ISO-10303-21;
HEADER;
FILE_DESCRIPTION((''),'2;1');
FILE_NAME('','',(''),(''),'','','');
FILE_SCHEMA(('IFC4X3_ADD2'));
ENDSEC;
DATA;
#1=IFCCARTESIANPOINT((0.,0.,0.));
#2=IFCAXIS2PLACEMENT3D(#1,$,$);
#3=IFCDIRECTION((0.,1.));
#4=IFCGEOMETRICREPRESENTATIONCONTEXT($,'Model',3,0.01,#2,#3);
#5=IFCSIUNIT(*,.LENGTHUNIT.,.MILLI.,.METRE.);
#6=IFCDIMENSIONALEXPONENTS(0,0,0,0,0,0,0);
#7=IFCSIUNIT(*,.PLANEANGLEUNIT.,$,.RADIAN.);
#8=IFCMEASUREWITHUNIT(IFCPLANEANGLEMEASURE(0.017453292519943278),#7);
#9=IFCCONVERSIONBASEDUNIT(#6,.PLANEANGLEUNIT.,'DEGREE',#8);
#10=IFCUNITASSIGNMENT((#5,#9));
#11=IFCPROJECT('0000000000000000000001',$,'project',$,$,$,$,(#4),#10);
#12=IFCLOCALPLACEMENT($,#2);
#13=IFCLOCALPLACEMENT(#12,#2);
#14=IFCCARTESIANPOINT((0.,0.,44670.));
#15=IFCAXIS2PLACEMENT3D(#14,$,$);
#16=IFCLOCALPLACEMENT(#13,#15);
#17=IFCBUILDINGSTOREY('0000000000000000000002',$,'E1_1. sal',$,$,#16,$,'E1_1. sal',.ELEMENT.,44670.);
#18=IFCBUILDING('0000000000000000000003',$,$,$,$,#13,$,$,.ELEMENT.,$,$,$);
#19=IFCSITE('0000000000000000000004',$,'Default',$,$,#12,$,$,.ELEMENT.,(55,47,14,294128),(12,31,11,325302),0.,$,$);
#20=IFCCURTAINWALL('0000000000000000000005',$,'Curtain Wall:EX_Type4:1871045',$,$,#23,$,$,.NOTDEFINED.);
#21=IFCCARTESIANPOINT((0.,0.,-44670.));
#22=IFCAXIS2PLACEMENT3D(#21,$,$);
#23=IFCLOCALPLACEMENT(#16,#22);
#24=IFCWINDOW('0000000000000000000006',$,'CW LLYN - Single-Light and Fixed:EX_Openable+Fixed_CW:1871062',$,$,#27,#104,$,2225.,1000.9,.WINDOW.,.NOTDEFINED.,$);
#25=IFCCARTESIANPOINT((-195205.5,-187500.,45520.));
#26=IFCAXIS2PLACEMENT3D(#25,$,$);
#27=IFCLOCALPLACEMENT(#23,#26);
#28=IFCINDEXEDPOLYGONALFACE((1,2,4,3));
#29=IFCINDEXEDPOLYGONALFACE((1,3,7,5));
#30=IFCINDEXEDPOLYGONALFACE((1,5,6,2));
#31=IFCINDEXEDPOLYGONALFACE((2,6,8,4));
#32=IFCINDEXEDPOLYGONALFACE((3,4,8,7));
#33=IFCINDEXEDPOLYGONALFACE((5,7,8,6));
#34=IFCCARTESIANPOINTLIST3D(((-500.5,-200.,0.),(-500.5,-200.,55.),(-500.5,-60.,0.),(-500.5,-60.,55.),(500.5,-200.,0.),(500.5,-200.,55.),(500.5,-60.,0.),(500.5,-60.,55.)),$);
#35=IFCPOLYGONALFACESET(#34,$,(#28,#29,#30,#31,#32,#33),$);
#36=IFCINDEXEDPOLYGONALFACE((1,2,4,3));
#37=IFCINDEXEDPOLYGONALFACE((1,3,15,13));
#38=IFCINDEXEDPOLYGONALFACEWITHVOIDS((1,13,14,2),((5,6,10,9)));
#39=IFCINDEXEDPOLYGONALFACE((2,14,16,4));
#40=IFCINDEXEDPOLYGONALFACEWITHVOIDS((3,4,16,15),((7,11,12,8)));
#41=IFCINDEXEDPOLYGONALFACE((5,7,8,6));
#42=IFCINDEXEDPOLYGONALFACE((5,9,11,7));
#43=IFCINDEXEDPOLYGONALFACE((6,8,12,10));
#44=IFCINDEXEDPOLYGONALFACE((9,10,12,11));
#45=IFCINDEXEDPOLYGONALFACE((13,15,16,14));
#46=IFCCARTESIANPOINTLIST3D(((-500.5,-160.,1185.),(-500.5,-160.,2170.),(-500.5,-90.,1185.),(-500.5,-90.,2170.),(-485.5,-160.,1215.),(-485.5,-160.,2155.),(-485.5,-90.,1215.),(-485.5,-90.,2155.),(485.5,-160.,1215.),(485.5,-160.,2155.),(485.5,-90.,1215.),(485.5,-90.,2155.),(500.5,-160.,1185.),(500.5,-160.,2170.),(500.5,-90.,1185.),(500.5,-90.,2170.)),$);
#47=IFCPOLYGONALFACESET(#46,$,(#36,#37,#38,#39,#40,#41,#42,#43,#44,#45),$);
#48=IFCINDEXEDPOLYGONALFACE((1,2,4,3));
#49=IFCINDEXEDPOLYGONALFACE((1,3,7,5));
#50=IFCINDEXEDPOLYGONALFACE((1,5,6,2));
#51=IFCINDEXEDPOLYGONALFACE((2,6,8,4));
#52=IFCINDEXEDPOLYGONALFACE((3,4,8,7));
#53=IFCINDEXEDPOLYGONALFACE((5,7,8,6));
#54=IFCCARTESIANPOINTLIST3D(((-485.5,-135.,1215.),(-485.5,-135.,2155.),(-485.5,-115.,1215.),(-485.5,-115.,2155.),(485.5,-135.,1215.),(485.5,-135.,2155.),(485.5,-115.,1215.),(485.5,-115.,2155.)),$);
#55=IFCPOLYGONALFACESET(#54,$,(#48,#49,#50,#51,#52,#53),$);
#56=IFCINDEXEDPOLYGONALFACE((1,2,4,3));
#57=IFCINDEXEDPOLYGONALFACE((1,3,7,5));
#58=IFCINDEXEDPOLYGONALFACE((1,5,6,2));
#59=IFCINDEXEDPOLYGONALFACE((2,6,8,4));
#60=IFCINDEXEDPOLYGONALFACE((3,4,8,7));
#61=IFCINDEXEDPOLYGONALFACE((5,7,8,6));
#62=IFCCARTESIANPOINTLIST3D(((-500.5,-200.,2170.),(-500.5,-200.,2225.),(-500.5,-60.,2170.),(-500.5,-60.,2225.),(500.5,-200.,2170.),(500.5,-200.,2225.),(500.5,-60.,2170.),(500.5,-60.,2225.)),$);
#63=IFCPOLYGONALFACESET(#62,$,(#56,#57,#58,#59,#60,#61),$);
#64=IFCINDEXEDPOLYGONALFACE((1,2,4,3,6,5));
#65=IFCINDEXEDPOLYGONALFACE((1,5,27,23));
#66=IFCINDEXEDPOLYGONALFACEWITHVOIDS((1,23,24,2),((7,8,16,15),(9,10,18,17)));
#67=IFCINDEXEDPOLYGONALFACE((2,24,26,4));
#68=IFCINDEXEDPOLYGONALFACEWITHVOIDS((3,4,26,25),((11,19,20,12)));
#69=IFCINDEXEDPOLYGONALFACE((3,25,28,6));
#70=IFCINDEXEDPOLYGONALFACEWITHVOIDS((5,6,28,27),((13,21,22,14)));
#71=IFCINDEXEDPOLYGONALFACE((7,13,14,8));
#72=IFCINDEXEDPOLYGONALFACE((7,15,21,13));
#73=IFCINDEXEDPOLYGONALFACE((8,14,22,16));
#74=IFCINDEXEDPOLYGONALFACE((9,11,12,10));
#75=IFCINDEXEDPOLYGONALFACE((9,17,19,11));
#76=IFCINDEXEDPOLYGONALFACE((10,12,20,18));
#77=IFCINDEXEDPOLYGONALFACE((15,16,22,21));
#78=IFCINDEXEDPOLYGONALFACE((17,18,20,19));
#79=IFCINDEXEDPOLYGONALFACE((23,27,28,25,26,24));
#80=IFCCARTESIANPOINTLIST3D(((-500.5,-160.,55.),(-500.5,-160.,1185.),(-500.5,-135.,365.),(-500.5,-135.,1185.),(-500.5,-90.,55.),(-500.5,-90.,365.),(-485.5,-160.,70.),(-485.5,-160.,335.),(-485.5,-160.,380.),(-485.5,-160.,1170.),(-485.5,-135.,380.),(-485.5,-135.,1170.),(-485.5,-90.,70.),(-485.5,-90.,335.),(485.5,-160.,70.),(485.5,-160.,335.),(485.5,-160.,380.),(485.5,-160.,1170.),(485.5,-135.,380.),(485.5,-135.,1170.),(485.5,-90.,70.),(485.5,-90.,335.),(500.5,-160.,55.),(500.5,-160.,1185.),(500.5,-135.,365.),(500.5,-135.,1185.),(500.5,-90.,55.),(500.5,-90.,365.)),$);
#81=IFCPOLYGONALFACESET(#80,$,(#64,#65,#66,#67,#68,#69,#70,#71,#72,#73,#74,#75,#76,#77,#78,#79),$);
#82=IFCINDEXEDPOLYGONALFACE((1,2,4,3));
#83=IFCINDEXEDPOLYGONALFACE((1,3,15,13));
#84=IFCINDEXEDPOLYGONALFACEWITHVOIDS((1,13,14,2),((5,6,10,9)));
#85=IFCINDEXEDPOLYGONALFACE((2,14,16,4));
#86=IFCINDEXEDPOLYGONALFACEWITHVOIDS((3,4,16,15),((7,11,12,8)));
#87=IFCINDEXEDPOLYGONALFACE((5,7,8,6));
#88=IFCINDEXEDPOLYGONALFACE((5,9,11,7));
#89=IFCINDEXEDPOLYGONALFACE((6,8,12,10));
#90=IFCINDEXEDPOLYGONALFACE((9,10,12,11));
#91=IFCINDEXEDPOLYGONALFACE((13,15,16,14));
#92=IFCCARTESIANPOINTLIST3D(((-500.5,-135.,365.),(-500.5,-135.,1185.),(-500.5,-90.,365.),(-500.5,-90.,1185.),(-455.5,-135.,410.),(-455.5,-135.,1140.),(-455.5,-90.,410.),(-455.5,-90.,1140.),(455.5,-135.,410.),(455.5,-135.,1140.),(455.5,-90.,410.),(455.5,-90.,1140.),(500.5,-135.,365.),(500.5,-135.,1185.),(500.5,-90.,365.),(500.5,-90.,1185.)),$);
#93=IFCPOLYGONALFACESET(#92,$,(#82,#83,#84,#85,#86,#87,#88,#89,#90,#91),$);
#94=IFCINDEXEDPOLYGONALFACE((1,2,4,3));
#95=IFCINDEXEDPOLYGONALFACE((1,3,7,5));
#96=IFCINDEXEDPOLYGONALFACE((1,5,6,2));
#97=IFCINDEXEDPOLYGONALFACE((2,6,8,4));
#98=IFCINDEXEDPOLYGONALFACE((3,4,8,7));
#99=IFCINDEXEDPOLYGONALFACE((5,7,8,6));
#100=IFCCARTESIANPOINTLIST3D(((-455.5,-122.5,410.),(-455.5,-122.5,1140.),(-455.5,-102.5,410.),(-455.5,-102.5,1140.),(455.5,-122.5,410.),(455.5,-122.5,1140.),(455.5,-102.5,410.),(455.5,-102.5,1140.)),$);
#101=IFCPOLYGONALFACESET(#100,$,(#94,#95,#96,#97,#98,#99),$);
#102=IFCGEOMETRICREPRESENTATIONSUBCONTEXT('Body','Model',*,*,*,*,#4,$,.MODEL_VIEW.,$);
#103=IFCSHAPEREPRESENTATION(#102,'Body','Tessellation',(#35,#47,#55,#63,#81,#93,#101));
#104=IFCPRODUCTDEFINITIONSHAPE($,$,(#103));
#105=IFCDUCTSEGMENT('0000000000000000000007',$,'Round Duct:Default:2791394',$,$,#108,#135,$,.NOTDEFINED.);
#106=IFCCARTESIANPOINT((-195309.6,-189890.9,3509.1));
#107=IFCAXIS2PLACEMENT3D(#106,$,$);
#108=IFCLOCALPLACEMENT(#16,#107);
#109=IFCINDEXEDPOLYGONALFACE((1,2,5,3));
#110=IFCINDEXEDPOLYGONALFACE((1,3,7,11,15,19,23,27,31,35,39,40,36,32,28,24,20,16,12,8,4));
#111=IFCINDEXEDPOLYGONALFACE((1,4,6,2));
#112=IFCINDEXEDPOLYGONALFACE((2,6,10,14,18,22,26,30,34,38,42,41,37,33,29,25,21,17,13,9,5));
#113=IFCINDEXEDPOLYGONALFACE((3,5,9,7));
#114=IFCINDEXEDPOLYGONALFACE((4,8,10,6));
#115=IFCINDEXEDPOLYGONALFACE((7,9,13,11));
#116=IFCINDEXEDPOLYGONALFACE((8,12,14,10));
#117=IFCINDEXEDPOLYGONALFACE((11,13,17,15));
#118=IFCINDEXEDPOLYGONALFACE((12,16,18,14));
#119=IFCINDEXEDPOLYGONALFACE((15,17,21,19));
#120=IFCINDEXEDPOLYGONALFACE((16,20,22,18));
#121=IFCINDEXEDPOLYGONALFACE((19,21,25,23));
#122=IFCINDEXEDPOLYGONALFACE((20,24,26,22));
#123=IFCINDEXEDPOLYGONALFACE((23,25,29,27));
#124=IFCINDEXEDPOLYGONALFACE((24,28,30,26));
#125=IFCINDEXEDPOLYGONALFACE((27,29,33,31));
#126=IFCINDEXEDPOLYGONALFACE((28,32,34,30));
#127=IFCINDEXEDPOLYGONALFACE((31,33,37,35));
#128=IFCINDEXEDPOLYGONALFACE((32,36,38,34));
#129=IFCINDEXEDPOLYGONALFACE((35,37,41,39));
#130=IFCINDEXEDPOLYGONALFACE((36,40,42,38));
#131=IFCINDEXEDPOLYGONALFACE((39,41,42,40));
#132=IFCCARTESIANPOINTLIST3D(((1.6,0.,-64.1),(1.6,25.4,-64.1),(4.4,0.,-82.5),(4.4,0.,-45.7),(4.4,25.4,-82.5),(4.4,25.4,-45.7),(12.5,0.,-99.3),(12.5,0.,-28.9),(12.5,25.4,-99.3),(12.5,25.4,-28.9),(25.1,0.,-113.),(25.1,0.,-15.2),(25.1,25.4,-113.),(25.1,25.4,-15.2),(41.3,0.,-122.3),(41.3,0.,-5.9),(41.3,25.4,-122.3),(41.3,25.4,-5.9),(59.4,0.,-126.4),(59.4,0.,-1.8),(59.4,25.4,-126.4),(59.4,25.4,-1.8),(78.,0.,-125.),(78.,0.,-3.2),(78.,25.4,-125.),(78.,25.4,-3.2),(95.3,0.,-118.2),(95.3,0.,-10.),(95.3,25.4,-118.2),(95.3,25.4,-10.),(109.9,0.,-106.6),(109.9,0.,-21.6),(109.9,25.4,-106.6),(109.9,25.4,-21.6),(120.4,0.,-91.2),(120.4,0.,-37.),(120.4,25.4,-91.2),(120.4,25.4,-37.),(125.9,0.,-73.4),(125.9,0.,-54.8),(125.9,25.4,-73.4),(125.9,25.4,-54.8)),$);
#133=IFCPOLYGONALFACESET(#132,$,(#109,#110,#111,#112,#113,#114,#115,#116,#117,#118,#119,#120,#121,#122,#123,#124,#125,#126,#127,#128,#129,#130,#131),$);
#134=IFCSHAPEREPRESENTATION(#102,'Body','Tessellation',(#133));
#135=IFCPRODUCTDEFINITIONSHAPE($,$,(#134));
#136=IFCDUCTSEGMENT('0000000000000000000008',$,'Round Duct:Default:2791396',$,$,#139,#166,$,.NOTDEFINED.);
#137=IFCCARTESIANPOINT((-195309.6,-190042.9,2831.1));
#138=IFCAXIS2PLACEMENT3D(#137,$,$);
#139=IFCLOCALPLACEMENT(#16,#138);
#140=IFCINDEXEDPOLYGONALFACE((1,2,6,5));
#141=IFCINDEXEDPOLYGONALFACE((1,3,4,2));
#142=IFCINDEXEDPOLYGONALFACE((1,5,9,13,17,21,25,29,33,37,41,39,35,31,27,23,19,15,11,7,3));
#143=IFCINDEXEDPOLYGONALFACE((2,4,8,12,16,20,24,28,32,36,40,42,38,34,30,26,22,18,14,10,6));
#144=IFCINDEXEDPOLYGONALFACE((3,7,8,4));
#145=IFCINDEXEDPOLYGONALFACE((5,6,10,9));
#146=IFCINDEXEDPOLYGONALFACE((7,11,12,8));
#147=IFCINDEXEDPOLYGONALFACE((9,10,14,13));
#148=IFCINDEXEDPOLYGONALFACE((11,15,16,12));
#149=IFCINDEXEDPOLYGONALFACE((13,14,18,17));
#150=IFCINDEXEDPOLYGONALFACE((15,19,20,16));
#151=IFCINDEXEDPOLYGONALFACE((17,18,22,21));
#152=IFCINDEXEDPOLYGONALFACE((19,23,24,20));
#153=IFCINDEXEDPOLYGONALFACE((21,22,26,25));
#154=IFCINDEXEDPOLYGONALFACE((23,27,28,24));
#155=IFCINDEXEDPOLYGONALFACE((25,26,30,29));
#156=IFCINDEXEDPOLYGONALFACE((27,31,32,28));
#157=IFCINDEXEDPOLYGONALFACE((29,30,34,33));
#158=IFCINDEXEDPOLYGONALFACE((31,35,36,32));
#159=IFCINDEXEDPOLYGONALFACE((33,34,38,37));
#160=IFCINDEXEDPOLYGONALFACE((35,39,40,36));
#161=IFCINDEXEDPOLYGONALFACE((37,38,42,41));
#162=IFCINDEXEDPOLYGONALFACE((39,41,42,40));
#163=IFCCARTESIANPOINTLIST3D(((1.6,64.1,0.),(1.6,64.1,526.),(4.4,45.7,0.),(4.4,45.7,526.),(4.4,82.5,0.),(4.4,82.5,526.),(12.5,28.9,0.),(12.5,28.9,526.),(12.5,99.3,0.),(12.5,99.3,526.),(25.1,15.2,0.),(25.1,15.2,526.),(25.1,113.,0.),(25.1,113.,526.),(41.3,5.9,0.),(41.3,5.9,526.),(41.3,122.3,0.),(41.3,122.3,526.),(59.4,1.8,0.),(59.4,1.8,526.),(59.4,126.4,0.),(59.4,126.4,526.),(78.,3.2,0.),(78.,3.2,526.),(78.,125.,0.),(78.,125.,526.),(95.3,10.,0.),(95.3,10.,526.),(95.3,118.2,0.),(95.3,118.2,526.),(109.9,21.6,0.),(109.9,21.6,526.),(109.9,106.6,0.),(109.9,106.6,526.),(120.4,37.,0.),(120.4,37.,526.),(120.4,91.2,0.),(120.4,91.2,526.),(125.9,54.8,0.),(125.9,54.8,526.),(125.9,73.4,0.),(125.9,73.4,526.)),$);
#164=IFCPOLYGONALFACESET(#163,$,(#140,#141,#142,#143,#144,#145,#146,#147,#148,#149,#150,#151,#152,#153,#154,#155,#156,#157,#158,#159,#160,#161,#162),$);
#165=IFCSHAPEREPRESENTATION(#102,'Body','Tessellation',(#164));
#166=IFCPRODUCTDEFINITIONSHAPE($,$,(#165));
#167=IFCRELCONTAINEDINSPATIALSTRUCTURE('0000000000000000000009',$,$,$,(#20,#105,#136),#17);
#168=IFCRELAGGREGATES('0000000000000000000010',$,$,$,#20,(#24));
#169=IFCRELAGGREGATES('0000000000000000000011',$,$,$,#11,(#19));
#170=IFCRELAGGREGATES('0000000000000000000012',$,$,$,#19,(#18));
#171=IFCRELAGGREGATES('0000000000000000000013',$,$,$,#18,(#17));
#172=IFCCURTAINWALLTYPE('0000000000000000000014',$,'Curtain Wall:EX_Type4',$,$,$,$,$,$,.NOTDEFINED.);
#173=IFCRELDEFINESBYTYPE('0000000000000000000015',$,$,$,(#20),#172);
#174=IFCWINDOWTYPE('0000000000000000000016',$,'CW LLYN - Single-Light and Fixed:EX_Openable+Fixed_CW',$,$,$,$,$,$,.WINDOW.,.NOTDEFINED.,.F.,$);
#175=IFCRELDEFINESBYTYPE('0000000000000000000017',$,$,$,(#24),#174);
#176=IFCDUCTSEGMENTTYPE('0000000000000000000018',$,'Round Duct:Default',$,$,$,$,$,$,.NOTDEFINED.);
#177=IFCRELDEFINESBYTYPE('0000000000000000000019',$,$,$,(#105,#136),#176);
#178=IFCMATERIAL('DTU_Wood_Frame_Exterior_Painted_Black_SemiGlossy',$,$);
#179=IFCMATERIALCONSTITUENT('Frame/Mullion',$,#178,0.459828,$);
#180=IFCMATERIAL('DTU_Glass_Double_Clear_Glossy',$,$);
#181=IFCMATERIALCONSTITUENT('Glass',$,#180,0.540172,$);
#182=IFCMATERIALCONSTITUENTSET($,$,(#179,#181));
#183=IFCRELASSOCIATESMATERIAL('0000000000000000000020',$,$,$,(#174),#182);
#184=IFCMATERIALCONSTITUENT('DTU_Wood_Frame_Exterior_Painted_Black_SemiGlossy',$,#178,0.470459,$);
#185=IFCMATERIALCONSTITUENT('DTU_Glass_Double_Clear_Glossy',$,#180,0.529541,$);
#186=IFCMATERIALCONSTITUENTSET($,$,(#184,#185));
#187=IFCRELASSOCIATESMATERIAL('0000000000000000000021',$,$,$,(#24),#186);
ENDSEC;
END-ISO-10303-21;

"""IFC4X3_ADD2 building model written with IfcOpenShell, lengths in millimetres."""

from ifc_helpers import new_model, entity, si_unit, converted_unit, direction, frame, frame_2d, origin, origin_2d_with_axis, place, context, subcontext, project, spatial, polyline, rectangle, circle, outline, extrude, source, transform, mapped, material, constituent, constituent_set, type_object, type_shapes, element, aggregate, save


model = new_model("IFC4X3_ADD2")

# Units and contexts
model_context = context("Model", 3, precision=0.01, world=origin(), true_north=direction((0.0, 1.0)))
body_context = subcontext(model_context, "Body", "Model", "MODEL_VIEW")
ifc_project = project(units=[si_unit("LENGTHUNIT", "METRE", prefix="MILLI"), converted_unit("PLANEANGLEUNIT", "DEGREE", entity("IfcPlaneAngleMeasure", 0.017453292519943278), si_unit("PLANEANGLEUNIT", "RADIAN"), dimensions=[0, 0, 0, 0, 0, 0, 0])], contexts=[model_context])

# Site, building, storey
site_placement = place(None, origin())
site = spatial("IfcSite", under=ifc_project, at=site_placement, Name="Default", CompositionType="ELEMENT", RefLatitude=(55, 47, 14, 294128), RefLongitude=(12, 31, 11, 325302), RefElevation=0.0)
building_placement = place(site_placement, origin())
building = spatial("IfcBuilding", under=site, at=building_placement, CompositionType="ELEMENT")
storey_placement = place(building_placement, frame((0.0, 0.0, 44670.0)))
storey = spatial("IfcBuildingStorey", under=building, at=storey_placement, Name="E1_1. sal", LongName="E1_1. sal", CompositionType="ELEMENT", Elevation=44670.0)

# Curtain wall, window, openings
curtain_wall_type = type_object("IfcCurtainWallType", Name="Curtain Wall:EX_Type4", PredefinedType="NOTDEFINED")
curtain_wall_placement = place(storey_placement, frame((0.0, 0.0, -44670.0)))
curtain_wall = element("IfcCurtainWall", 1, at=curtain_wall_placement, inside=storey, type_object=curtain_wall_type, Name="Curtain Wall:EX_Type4:1871045", PredefinedType="NOTDEFINED")
ifc_material_1 = material(Name="DTU_Wood_Frame_Exterior_Painted_Black_SemiGlossy")
ifc_material_2 = material(Name="DTU_Glass_Double_Clear_Glossy")
ifc_constituent_1 = constituent(ifc_material_1, Name="DTU_Wood_Frame_Exterior_Painted_Black_SemiGlossy", fraction=0.470459)
ifc_constituent_2 = constituent(ifc_material_2, Name="DTU_Glass_Double_Clear_Glossy", fraction=0.529541)
ifc_constituent_set_1 = constituent_set(constituents=[ifc_constituent_1, ifc_constituent_2])
ifc_constituent_3 = constituent(ifc_material_1, Name="Frame/Mullion", fraction=0.459828)
ifc_constituent_4 = constituent(ifc_material_2, Name="Glass", fraction=0.540172)
ifc_constituent_set_2 = constituent_set(constituents=[ifc_constituent_3, ifc_constituent_4])
window_type_1 = type_object("IfcWindowType", Name="CW LLYN - Single-Light and Fixed:EX_Openable+Fixed_CW", ParameterTakesPrecedence=False, PartitioningType="NOTDEFINED", PredefinedType="WINDOW", material=ifc_constituent_set_2)
shared_shape_1 = source(origin(), body_context, "Body", "SweptSolid", [
    extrude(rectangle(XDim=140.0, YDim=1000.9, at=frame_2d((0.0, 0.0), x_axis=(1.0, 0.0))), frame((0.0, -130.0, 0.0), z_axis=(0.0, 0.0, 1.0), x_axis=(0.0, -1.0, 0.0)), (0.0, 0.0, 1.0), 55.0),
    extrude(outline(polyline([(-492.5, -500.5), (492.5, -500.5), (492.5, 500.5), (-492.5, 500.5), (-492.5, -500.5)]), holes=[polyline([(477.5, -485.5), (-462.5, -485.5), (-462.5, 485.5), (477.5, 485.5), (477.5, -485.5)])]), frame((0.0, -90.0, 1677.5), z_axis=(0.0, -1.0, 0.0), x_axis=(0.0, 0.0, 1.0)), (0.0, 0.0, 1.0), 70.0),
    extrude(rectangle(XDim=970.9, YDim=20.0, at=frame_2d((0.0, 0.0), x_axis=(1.0, 0.0))), frame((0.0, -125.0, 1215.0), z_axis=(0.0, 0.0, 1.0), x_axis=(-1.0, 0.0, 0.0)), (0.0, 0.0, 1.0), 940.0),
    extrude(rectangle(XDim=970.9, YDim=20.0, at=frame_2d((0.0, 0.0), x_axis=(1.0, 0.0))), frame((0.0, -125.0, 70.0), z_axis=(0.0, 0.0, 1.0), x_axis=(-1.0, 0.0, 0.0)), (0.0, 0.0, 1.0), 265.0),
    extrude(rectangle(XDim=140.0, YDim=1000.9, at=frame_2d((0.0, 0.0), x_axis=(1.0, 0.0))), frame((0.0, -130.0, 2170.0), z_axis=(0.0, 0.0, 1.0), x_axis=(0.0, -1.0, 0.0)), (0.0, 0.0, 1.0), 55.0),
    extrude(outline(polyline([(-38.3, -480.0), (31.7, -480.0), (31.7, 650.0), (6.7, 650.0), (6.7, -170.0), (-38.3, -170.0), (-38.3, -480.0)])), frame((500.5, -128.3, 535.0), z_axis=(-1.0, 0.0, 0.0), x_axis=(0.0, -1.0, 0.0)), (0.0, 0.0, 1.0), 1000.9),
    extrude(outline(polyline([(-410.0, -500.5), (410.0, -500.5), (410.0, 500.5), (-410.0, 500.5), (-410.0, -500.5)]), holes=[polyline([(-365.0, 455.5), (365.0, 455.5), (365.0, -455.5), (-365.0, -455.5), (-365.0, 455.5)])]), frame((0.0, -90.0, 775.0), z_axis=(0.0, -1.0, 0.0), x_axis=(0.0, 0.0, 1.0)), (0.0, 0.0, 1.0), 45.0),
    extrude(rectangle(XDim=910.9, YDim=20.0, at=frame_2d((0.0, 0.0), x_axis=(1.0, 0.0))), frame((0.0, -112.5, 410.0), z_axis=(0.0, 0.0, 1.0), x_axis=(-1.0, 0.0, 0.0)), (0.0, 0.0, 1.0), 730.0),
])
type_shapes(window_type_1, [shared_shape_1])
window_1_placement = place(curtain_wall_placement, frame((-195205.5, -187500.0, 45520.0)))
window_1 = element("IfcWindow", 2, at=window_1_placement, type_object=window_type_1, material=ifc_constituent_set_1, Name="CW LLYN - Single-Light and Fixed:EX_Openable+Fixed_CW:1871062", OverallHeight=2225.0, OverallWidth=1000.9, PartitioningType="NOTDEFINED", PredefinedType="WINDOW", context=body_context, shape_type="MappedRepresentation", body=[
    mapped(shared_shape_1, transform((0.0, 0.0, 0.0), scale=1.0)),
])
opening_1_placement = place(curtain_wall_placement, frame((-195205.5, -187500.0, 90190.0), z_axis=(0.0, 0.0, 1.0), x_axis=(-1.0, 0.0, 0.0)))
opening_1 = element("IfcOpeningElement", 3, at=opening_1_placement, cuts=window_1, PredefinedType="OPENING", context=body_context, shape_type="SweptSolid", body=[
    extrude(rectangle(XDim=265.0, YDim=970.9, at=frame_2d((0.0, 0.0), x_axis=(1.0, 0.0))), frame((0.0, 160.0, -44467.5), z_axis=(0.0, -1.0, 0.0), x_axis=(0.0, 0.0, 1.0)), (0.0, 0.0, 1.0), 70.0),
])
opening_2_placement = place(curtain_wall_placement, frame((-195205.5, -187500.0, 90190.0), z_axis=(0.0, 0.0, 1.0), x_axis=(-1.0, 0.0, 0.0)))
opening_2 = element("IfcOpeningElement", 4, at=opening_2_placement, cuts=window_1, PredefinedType="OPENING", context=body_context, shape_type="SweptSolid", body=[
    extrude(rectangle(XDim=790.0, YDim=970.9, at=frame_2d((0.0, 0.0), x_axis=(1.0, 0.0))), frame((0.0, 135.0, -43895.0), z_axis=(0.0, 1.0, 0.0), x_axis=(0.0, 0.0, 1.0)), (0.0, 0.0, 1.0), 25.0),
])
aggregate(curtain_wall, [window_1, opening_1, opening_2])

# Duct segments
duct_segment_type = type_object("IfcDuctSegmentType", Name="Round Duct:Default", PredefinedType="NOTDEFINED")
duct_segment_1_placement = place(storey_placement, frame((-195309.6, -189890.9, 3509.1)))
element("IfcDuctSegment", 5, at=duct_segment_1_placement, inside=storey, type_object=duct_segment_type, Name="Round Duct:Default:2791394", PredefinedType="NOTDEFINED", context=body_context, shape_type="SweptSolid", body=[
    extrude(circle(Radius=62.5, at=origin_2d_with_axis()), frame((64.1, 0.0, -64.1), z_axis=(0.0, 1.0, 0.0), x_axis=(-1.0, 0.0, 0.0)), (0.0, 0.0, 1.0), 25.4),
])
duct_segment_2_placement = place(storey_placement, frame((-195309.6, -190042.9, 2831.1)))
element("IfcDuctSegment", 6, at=duct_segment_2_placement, inside=storey, type_object=duct_segment_type, Name="Round Duct:Default:2791396", PredefinedType="NOTDEFINED", context=body_context, shape_type="SweptSolid", body=[
    extrude(circle(Radius=62.5, at=frame_2d((0.0, 0.0), x_axis=(1.0, 0.0))), frame((64.1, 64.1, 0.0), z_axis=(0.0, 0.0, 1.0), x_axis=(-1.0, 0.0, 0.0)), (0.0, 0.0, 1.0), 526.0),
])

save(model, "model.ifc")
